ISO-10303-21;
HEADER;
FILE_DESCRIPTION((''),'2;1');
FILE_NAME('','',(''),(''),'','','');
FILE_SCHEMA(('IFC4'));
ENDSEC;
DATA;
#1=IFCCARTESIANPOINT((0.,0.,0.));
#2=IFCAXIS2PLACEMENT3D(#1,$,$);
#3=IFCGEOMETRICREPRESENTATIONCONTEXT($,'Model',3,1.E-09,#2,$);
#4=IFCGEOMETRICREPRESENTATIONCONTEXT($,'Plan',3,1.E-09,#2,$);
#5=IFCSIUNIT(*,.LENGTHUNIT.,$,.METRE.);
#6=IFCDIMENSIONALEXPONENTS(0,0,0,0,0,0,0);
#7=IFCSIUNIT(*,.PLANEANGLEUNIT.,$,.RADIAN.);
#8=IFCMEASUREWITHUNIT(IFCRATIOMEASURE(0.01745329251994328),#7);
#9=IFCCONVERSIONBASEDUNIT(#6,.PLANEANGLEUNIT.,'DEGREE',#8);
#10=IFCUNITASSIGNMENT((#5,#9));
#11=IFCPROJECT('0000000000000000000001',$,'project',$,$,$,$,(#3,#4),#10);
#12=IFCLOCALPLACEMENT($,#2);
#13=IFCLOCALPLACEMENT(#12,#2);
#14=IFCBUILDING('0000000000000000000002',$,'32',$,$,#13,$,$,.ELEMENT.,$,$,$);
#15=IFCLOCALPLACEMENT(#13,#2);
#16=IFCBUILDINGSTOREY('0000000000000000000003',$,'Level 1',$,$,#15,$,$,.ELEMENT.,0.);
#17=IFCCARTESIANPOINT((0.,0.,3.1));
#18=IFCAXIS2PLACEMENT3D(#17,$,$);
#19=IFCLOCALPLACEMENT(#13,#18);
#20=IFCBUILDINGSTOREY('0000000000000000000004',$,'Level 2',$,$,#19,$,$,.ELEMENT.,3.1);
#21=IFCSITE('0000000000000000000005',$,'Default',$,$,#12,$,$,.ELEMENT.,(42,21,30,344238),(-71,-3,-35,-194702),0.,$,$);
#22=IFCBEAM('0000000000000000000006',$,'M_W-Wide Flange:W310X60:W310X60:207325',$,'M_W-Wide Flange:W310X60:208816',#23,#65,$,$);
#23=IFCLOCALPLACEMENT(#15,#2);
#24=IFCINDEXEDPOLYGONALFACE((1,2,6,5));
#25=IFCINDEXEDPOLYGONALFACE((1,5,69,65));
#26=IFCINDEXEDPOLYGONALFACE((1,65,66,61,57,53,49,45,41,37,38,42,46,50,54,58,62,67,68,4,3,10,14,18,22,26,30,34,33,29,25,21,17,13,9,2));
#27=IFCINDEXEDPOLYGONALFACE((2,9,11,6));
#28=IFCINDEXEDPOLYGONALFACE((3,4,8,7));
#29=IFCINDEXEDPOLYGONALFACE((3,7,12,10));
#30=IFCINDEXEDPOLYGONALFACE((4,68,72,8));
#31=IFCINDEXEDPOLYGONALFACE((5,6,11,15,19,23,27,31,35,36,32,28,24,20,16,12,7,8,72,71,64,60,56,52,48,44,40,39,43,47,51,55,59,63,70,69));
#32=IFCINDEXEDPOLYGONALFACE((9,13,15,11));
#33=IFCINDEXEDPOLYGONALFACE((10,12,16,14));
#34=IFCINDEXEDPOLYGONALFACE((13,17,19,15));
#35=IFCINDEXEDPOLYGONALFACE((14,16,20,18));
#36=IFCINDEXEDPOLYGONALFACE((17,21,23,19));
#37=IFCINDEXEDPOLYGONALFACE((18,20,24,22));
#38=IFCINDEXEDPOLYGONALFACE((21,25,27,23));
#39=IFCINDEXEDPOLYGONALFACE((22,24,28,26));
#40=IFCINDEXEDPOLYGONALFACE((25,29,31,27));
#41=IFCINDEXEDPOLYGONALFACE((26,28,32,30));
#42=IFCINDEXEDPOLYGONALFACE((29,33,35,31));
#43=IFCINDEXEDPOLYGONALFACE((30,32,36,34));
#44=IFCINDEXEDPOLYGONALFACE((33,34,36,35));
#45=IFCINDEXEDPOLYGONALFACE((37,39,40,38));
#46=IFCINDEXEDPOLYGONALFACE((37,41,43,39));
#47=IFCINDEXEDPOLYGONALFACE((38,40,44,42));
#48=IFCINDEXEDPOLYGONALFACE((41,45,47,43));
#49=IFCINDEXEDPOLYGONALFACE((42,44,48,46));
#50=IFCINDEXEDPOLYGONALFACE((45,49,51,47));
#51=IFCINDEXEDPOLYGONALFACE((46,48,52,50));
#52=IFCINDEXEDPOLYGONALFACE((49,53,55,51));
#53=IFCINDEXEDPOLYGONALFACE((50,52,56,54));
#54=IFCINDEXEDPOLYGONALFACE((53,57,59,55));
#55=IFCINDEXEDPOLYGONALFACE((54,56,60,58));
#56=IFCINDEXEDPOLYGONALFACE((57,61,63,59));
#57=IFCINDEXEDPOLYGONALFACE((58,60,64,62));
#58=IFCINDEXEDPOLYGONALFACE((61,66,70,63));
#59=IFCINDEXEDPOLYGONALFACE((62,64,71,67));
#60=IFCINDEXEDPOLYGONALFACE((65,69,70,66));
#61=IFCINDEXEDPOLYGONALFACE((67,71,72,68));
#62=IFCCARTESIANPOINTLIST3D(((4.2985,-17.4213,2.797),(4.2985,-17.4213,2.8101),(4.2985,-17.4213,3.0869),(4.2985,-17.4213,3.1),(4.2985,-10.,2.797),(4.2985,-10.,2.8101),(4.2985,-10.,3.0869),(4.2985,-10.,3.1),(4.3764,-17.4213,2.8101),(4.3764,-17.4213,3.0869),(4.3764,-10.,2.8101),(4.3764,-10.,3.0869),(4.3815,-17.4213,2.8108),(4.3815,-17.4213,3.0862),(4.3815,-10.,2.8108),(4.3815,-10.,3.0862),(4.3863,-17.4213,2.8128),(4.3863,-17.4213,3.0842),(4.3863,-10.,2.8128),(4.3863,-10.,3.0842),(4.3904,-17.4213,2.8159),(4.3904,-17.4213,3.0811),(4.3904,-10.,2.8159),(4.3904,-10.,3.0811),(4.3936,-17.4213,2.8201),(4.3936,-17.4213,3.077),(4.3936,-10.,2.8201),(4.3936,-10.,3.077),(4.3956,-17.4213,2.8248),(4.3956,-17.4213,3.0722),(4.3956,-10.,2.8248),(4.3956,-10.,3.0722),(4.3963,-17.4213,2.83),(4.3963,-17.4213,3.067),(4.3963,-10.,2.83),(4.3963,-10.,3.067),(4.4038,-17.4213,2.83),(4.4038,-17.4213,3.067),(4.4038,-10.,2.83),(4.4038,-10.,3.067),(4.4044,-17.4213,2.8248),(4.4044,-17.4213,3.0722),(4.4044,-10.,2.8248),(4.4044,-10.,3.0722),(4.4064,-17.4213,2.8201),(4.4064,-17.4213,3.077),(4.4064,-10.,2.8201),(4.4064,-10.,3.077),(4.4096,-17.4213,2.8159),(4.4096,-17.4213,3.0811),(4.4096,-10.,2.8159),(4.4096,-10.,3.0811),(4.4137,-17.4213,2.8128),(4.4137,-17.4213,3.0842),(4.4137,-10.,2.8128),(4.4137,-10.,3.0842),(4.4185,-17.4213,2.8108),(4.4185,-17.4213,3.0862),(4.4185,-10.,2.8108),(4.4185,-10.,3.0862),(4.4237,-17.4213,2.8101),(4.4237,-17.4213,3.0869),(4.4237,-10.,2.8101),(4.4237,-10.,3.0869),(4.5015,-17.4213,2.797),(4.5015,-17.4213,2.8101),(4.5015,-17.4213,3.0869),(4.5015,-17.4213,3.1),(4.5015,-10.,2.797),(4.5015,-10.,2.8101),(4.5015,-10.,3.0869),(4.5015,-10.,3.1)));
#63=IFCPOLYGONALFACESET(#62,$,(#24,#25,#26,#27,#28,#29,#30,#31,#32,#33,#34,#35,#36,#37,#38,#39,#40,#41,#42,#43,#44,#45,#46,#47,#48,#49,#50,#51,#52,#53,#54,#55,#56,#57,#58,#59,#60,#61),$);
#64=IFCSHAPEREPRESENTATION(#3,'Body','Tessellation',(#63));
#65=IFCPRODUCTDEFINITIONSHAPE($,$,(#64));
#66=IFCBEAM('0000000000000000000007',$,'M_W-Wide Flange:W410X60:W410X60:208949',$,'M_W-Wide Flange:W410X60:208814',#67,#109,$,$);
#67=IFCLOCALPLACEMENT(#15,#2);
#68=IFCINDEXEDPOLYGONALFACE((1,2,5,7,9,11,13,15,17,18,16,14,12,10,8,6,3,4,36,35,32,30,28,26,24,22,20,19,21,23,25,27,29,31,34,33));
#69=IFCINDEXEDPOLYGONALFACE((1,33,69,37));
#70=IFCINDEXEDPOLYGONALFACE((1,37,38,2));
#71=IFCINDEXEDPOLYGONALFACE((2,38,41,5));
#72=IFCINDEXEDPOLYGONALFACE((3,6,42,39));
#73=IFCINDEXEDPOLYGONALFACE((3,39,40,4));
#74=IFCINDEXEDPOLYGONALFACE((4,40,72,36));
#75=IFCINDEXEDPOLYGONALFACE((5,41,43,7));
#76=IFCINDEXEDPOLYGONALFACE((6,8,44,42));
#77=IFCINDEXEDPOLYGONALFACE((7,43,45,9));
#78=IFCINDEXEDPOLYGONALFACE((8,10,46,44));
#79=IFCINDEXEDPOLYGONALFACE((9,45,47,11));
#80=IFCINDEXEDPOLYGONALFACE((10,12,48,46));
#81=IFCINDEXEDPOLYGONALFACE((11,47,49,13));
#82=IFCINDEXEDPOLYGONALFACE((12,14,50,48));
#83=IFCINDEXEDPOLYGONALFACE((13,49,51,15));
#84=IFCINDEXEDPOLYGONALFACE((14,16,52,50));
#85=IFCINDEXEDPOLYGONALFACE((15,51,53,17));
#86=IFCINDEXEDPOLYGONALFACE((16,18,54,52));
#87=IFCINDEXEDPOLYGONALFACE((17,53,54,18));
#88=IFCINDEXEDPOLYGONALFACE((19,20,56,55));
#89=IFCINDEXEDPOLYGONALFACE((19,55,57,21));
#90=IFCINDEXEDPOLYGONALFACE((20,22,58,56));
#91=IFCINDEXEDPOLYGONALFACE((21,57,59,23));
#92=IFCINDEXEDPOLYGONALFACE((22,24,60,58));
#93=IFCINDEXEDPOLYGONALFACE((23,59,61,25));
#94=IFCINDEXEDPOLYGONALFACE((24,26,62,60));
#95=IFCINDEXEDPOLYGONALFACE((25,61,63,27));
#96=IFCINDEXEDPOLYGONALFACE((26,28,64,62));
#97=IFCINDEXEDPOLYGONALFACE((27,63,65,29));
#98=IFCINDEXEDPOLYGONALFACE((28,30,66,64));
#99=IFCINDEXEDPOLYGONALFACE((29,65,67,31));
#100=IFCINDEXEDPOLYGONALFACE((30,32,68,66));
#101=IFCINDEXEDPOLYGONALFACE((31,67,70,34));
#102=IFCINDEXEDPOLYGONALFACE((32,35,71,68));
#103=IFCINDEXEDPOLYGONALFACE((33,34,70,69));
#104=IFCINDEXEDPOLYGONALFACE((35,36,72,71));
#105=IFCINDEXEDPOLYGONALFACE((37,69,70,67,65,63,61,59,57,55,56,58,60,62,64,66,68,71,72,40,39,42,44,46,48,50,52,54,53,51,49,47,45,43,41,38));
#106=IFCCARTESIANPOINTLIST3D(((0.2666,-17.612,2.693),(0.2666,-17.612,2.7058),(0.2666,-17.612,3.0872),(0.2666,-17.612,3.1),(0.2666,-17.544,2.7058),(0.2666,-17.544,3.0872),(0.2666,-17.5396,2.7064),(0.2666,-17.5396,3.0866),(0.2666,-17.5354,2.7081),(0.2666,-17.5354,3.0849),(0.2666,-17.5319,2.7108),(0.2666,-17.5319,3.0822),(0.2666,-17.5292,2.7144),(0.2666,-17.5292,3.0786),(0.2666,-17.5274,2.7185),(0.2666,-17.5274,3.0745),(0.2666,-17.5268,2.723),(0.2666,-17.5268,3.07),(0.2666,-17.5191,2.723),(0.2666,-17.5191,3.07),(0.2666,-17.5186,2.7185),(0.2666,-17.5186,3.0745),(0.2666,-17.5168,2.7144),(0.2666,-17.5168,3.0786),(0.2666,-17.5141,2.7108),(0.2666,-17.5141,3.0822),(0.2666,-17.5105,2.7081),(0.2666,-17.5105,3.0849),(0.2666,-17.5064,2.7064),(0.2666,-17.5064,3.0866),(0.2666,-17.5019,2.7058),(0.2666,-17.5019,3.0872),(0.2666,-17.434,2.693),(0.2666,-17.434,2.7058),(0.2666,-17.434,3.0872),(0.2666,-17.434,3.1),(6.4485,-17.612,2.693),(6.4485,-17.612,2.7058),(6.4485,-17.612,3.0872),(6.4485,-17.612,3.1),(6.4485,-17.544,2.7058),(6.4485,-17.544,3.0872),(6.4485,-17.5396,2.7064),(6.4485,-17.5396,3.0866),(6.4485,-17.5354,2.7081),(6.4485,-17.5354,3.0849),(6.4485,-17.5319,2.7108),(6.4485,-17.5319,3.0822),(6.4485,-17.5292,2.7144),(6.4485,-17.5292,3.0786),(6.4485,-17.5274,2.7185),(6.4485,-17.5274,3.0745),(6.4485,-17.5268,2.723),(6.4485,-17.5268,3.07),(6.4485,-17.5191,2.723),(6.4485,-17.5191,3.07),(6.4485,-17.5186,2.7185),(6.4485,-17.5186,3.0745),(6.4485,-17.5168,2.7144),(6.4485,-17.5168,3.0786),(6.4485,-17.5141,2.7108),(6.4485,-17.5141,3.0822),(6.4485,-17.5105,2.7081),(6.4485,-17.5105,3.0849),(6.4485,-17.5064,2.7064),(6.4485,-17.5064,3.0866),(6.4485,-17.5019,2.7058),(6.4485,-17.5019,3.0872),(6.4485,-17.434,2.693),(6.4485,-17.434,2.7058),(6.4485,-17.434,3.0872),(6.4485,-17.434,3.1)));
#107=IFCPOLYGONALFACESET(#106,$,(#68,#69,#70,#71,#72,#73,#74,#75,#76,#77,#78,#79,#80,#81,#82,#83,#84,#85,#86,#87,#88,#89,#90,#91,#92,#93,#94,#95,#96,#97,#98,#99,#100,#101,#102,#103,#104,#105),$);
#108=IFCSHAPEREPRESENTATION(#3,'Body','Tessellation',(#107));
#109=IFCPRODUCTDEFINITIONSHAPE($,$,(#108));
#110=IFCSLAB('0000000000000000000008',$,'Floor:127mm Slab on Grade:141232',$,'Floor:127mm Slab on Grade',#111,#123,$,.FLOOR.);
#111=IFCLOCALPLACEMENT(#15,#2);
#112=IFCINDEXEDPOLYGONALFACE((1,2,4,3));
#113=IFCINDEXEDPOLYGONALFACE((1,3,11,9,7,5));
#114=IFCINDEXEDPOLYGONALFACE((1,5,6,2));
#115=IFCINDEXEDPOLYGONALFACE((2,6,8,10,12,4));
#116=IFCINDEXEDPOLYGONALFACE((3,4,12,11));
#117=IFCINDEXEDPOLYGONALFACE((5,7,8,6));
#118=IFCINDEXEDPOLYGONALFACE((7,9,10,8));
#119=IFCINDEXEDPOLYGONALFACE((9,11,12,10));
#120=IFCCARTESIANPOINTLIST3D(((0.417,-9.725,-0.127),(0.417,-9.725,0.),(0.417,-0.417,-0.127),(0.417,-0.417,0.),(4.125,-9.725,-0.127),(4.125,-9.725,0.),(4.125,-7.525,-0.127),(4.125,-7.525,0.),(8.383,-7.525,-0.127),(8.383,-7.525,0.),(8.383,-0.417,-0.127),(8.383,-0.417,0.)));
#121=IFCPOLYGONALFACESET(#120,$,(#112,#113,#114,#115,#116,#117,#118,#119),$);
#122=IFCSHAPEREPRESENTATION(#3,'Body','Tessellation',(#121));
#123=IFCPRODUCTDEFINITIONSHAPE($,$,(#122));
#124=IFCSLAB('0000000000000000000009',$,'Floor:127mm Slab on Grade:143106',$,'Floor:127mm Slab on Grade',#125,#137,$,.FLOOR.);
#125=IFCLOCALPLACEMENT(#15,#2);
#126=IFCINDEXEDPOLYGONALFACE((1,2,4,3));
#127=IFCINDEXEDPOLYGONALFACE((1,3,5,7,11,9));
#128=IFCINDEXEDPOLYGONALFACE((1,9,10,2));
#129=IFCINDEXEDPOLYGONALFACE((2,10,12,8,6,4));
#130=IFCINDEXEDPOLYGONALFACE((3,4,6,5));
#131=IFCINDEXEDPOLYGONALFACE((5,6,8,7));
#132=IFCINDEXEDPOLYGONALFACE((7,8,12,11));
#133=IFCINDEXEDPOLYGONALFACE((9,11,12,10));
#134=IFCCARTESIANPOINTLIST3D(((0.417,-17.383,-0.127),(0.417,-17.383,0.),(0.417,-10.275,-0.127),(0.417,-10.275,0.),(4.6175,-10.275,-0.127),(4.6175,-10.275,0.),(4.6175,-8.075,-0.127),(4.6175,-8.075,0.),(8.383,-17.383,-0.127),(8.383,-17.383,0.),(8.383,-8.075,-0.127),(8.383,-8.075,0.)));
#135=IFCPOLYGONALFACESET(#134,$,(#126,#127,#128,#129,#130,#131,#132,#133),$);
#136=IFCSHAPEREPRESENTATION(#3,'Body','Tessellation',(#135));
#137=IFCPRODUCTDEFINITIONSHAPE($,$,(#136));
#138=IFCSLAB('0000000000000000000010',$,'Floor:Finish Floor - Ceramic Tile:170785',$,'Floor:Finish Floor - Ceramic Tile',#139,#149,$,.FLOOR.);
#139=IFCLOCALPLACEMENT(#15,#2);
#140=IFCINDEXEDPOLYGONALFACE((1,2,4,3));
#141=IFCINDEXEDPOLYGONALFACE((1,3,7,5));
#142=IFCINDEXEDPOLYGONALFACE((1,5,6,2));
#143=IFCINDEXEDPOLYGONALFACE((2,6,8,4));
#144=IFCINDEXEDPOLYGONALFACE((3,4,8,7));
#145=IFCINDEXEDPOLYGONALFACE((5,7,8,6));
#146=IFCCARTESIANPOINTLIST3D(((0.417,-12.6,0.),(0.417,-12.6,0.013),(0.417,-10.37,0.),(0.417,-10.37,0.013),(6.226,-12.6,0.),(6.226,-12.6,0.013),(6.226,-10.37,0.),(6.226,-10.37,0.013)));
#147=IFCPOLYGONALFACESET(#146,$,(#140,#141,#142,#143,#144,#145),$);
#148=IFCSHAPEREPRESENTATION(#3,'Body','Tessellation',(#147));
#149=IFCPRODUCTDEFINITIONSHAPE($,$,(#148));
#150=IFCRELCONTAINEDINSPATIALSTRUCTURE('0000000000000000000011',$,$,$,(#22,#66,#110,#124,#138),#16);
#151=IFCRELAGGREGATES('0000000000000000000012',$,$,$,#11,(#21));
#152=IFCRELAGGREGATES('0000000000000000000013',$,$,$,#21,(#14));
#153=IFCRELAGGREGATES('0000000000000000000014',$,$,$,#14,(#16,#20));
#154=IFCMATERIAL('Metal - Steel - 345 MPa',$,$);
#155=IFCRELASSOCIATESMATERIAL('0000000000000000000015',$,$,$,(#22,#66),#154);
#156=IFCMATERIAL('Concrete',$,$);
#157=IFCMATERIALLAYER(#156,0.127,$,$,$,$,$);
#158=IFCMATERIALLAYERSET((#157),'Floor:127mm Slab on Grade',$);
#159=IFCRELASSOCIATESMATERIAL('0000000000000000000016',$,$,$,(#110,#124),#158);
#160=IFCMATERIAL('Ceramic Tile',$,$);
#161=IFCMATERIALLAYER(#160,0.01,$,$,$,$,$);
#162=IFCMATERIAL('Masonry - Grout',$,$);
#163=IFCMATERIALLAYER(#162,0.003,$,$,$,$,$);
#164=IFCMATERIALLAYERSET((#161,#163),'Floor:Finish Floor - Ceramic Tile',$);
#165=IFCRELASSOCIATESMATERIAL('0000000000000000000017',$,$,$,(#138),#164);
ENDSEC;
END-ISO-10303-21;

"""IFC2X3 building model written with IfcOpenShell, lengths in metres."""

from ifc_helpers import new_model, entity, si_unit, converted_unit, frame, frame_2d, origin, place, context, project, spatial, polyline, circle_curve, parameter, trimmed, segment, composite_curve, rectangle, outline, extrude, material, layer, layer_set, layer_usage, element, save


model = new_model("IFC2X3")

# Units and contexts
model_context = context("Model", 3, precision=1e-09, world=origin())
plan_context = context("Plan", 3, precision=1e-09, world=origin())
ifc_project = project(units=[si_unit("LENGTHUNIT", "METRE"), converted_unit("PLANEANGLEUNIT", "DEGREE", entity("IfcRatioMeasure", 0.01745329251994328), si_unit("PLANEANGLEUNIT", "RADIAN"), dimensions=[0, 0, 0, 0, 0, 0, 0])], contexts=[model_context, plan_context])

# Site, building, storey
site_placement = place(None, origin())
site = spatial("IfcSite", under=ifc_project, at=site_placement, Name="Default", CompositionType="ELEMENT", RefLatitude=(42, 21, 30, 344238), RefLongitude=(-71, -3, -35, -194702), RefElevation=0.0)
building_placement = place(site_placement, origin())
building = spatial("IfcBuilding", under=site, at=building_placement, Name="32", CompositionType="ELEMENT")
storey_1_placement = place(building_placement, origin())
storey_1 = spatial("IfcBuildingStorey", under=building, at=storey_1_placement, Name="Level 1", CompositionType="ELEMENT", Elevation=0.0)

# Beams
ifc_material_1 = material(Name="Metal - Steel - 345 MPa")
beam_1_placement = place(storey_1_placement, frame((4.4, -10.0, 3.1), z_axis=(0.0, 0.0, 1.0), x_axis=(-1.0, 0.0, 0.0)))
element("IfcBeam", 1, at=beam_1_placement, inside=storey_1, material=ifc_material_1, Name="M_W-Wide Flange:W310X60:W310X60:207325", ObjectType="M_W-Wide Flange:W310X60:208816", context=model_context, shape_type="SweptSolid", body=[
    extrude(outline(composite_curve([segment(polyline([(0.1384, -0.1015), (0.1515, -0.1015)]), True, "CONTINUOUS"), segment(polyline([(0.1515, -0.1015), (0.1515, 0.1015)]), True, "CONTINUOUS"), segment(polyline([(0.1515, 0.1015), (0.1384, 0.1015)]), True, "CONTINUOUS"), segment(polyline([(0.1384, 0.1015), (0.1384, 0.0236)]), True, "CONTINUOUS"), segment(trimmed(circle_curve(frame_2d((0.1185, 0.0236), x_axis=(0.0, 1.0)), 0.0199), [parameter(180.0)], [parameter(270.0)], True, "PARAMETER"), False, "CONTINUOUS"), segment(polyline([(0.1185, 0.0037), (-0.1185, 0.0037)]), True, "CONTINUOUS"), segment(trimmed(circle_curve(frame_2d((-0.1185, 0.0236), x_axis=(0.0, 1.0)), 0.0199), [parameter(90.0)], [parameter(180.0)], True, "PARAMETER"), False, "CONTINUOUS"), segment(polyline([(-0.1384, 0.0236), (-0.1384, 0.1015)]), True, "CONTINUOUS"), segment(polyline([(-0.1384, 0.1015), (-0.1515, 0.1015)]), True, "CONTINUOUS"), segment(polyline([(-0.1515, 0.1015), (-0.1515, -0.1015)]), True, "CONTINUOUS"), segment(polyline([(-0.1515, -0.1015), (-0.1384, -0.1015)]), True, "CONTINUOUS"), segment(polyline([(-0.1384, -0.1015), (-0.1384, -0.0237)]), True, "CONTINUOUS"), segment(trimmed(circle_curve(frame_2d((-0.1185, -0.0237), x_axis=(0.0, 1.0)), 0.0199), [parameter(360.0)], [parameter(90.0)], True, "PARAMETER"), False, "CONTINUOUS"), segment(polyline([(-0.1185, -0.0038), (0.1185, -0.0038)]), True, "CONTINUOUS"), segment(trimmed(circle_curve(frame_2d((0.1185, -0.0237), x_axis=(0.0, 1.0)), 0.0199), [parameter(270.0)], [parameter(0.0)], True, "PARAMETER"), False, "CONTINUOUS"), segment(polyline([(0.1384, -0.0237), (0.1384, -0.1015)]), True, "CONTINUOUS")], self_intersect=False)), frame((0.0, 7.4213, -0.1515), z_axis=(0.0, -1.0, 0.0), x_axis=(0.0, 0.0, -1.0)), (0.0, 0.0, 1.0), 7.4213),
])
beam_2_placement = place(storey_1_placement, frame((0.2085, -17.523, 3.1), z_axis=(0.0, 0.0, 1.0), x_axis=(0.0, -1.0, 0.0)))
element("IfcBeam", 2, at=beam_2_placement, inside=storey_1, material=ifc_material_1, Name="M_W-Wide Flange:W410X60:W410X60:208949", ObjectType="M_W-Wide Flange:W410X60:208814", context=model_context, shape_type="SweptSolid", body=[
    extrude(outline(composite_curve([segment(polyline([(-0.089, -0.1907), (-0.089, -0.2035)]), True, "CONTINUOUS"), segment(polyline([(-0.089, -0.2035), (0.089, -0.2035)]), True, "CONTINUOUS"), segment(polyline([(0.089, -0.2035), (0.089, -0.1907)]), True, "CONTINUOUS"), segment(polyline([(0.089, -0.1907), (0.021, -0.1907)]), True, "CONTINUOUS"), segment(trimmed(circle_curve(frame_2d((0.021, -0.1735), x_axis=(0.0, -1.0)), 0.0172), [parameter(270.0)], [parameter(360.0)], True, "PARAMETER"), False, "CONTINUOUS"), segment(polyline([(0.0038, -0.1735), (0.0038, 0.1735)]), True, "CONTINUOUS"), segment(trimmed(circle_curve(frame_2d((0.021, 0.1735), x_axis=(-1.0, 0.0)), 0.0172), [parameter(270.0)], [parameter(360.0)], True, "PARAMETER"), False, "CONTINUOUS"), segment(polyline([(0.021, 0.1907), (0.089, 0.1907)]), True, "CONTINUOUS"), segment(polyline([(0.089, 0.1907), (0.089, 0.2035)]), True, "CONTINUOUS"), segment(polyline([(0.089, 0.2035), (-0.089, 0.2035)]), True, "CONTINUOUS"), segment(polyline([(-0.089, 0.2035), (-0.089, 0.1907)]), True, "CONTINUOUS"), segment(polyline([(-0.089, 0.1907), (-0.0211, 0.1907)]), True, "CONTINUOUS"), segment(trimmed(circle_curve(frame_2d((-0.0211, 0.1735), x_axis=(0.0, 1.0)), 0.0172), [parameter(270.0)], [parameter(0.0)], True, "PARAMETER"), False, "CONTINUOUS"), segment(polyline([(-0.0039, 0.1735), (-0.0039, -0.1735)]), True, "CONTINUOUS"), segment(trimmed(circle_curve(frame_2d((-0.0211, -0.1735), x_axis=(1.0, 0.0)), 0.0172), [parameter(270.0)], [parameter(0.0)], True, "PARAMETER"), False, "CONTINUOUS"), segment(polyline([(-0.0211, -0.1907), (-0.089, -0.1907)]), True, "CONTINUOUS")], self_intersect=False)), frame((0.0, 0.0581, -0.2035), z_axis=(0.0, -1.0, 0.0), x_axis=(1.0, 0.0, 0.0)), (0.0, 0.0, -1.0), 6.1819),
])

# Slabs
ifc_material_2 = material(Name="Concrete")
ifc_layer_1 = layer(ifc_material_2, 0.127)
ifc_layer_set_1 = layer_set([ifc_layer_1], Name="Floor:127mm Slab on Grade")
ifc_layer_usage_1 = layer_usage(ifc_layer_set_1, "AXIS3", "POSITIVE", 0.0)
slab_1_placement = place(storey_1_placement, frame((0.417, -9.725, -0.127)))
element("IfcSlab", 3, at=slab_1_placement, inside=storey_1, material=ifc_layer_usage_1, Name="Floor:127mm Slab on Grade:141232", ObjectType="Floor:127mm Slab on Grade", PredefinedType="FLOOR", context=model_context, shape_type="SweptSolid", body=[
    extrude(outline(polyline([(-3.983, 4.654), (-3.983, -2.454), (0.275, -2.454), (0.275, -4.654), (3.983, -4.654), (3.983, 4.654), (-3.983, 4.654)])), frame((3.983, 4.654, 0.127), z_axis=(0.0, 0.0, -1.0), x_axis=(-1.0, 0.0, 0.0)), (0.0, 0.0, 1.0), 0.127),
])
ifc_layer_usage_2 = layer_usage(ifc_layer_set_1, "AXIS3", "POSITIVE", 0.0)
slab_2_placement = place(storey_1_placement, frame((0.417, -17.383, -0.127)))
element("IfcSlab", 4, at=slab_2_placement, inside=storey_1, material=ifc_layer_usage_2, Name="Floor:127mm Slab on Grade:143106", ObjectType="Floor:127mm Slab on Grade", PredefinedType="FLOOR", context=model_context, shape_type="SweptSolid", body=[
    extrude(outline(polyline([(-3.983, 4.654), (-3.983, -4.654), (3.983, -4.654), (3.983, 2.454), (-0.2175, 2.454), (-0.2175, 4.654), (-3.983, 4.654)])), frame((3.983, 4.654, 0.127), z_axis=(0.0, 0.0, -1.0), x_axis=(-1.0, 0.0, 0.0)), (0.0, 0.0, 1.0), 0.127),
])
ifc_material_3 = material(Name="Ceramic Tile")
ifc_layer_2 = layer(ifc_material_3, 0.01)
ifc_material_4 = material(Name="Masonry - Grout")
ifc_layer_3 = layer(ifc_material_4, 0.003)
ifc_layer_set_2 = layer_set([ifc_layer_2, ifc_layer_3], Name="Floor:Finish Floor - Ceramic Tile")
ifc_layer_usage_3 = layer_usage(ifc_layer_set_2, "AXIS3", "POSITIVE", 0.0)
slab_3_placement = place(storey_1_placement, frame((0.417, -12.6, 0.0)))
element("IfcSlab", 5, at=slab_3_placement, inside=storey_1, material=ifc_layer_usage_3, Name="Floor:Finish Floor - Ceramic Tile:170785", ObjectType="Floor:Finish Floor - Ceramic Tile", PredefinedType="FLOOR", context=model_context, shape_type="SweptSolid", body=[
    extrude(rectangle(XDim=5.809, YDim=2.23, at=frame_2d((0.0, 0.0), x_axis=(-1.0, 0.0))), frame((2.9045, 1.115, 0.013), z_axis=(0.0, 0.0, -1.0), x_axis=(-1.0, 0.0, 0.0)), (0.0, 0.0, 1.0), 0.013),
])

# Shared definitions
storey_2_placement = place(building_placement, frame((0.0, 0.0, 3.1)))
storey_2 = spatial("IfcBuildingStorey", under=building, at=storey_2_placement, Name="Level 2", CompositionType="ELEMENT", Elevation=3.1)

save(model, "model.ifc")
